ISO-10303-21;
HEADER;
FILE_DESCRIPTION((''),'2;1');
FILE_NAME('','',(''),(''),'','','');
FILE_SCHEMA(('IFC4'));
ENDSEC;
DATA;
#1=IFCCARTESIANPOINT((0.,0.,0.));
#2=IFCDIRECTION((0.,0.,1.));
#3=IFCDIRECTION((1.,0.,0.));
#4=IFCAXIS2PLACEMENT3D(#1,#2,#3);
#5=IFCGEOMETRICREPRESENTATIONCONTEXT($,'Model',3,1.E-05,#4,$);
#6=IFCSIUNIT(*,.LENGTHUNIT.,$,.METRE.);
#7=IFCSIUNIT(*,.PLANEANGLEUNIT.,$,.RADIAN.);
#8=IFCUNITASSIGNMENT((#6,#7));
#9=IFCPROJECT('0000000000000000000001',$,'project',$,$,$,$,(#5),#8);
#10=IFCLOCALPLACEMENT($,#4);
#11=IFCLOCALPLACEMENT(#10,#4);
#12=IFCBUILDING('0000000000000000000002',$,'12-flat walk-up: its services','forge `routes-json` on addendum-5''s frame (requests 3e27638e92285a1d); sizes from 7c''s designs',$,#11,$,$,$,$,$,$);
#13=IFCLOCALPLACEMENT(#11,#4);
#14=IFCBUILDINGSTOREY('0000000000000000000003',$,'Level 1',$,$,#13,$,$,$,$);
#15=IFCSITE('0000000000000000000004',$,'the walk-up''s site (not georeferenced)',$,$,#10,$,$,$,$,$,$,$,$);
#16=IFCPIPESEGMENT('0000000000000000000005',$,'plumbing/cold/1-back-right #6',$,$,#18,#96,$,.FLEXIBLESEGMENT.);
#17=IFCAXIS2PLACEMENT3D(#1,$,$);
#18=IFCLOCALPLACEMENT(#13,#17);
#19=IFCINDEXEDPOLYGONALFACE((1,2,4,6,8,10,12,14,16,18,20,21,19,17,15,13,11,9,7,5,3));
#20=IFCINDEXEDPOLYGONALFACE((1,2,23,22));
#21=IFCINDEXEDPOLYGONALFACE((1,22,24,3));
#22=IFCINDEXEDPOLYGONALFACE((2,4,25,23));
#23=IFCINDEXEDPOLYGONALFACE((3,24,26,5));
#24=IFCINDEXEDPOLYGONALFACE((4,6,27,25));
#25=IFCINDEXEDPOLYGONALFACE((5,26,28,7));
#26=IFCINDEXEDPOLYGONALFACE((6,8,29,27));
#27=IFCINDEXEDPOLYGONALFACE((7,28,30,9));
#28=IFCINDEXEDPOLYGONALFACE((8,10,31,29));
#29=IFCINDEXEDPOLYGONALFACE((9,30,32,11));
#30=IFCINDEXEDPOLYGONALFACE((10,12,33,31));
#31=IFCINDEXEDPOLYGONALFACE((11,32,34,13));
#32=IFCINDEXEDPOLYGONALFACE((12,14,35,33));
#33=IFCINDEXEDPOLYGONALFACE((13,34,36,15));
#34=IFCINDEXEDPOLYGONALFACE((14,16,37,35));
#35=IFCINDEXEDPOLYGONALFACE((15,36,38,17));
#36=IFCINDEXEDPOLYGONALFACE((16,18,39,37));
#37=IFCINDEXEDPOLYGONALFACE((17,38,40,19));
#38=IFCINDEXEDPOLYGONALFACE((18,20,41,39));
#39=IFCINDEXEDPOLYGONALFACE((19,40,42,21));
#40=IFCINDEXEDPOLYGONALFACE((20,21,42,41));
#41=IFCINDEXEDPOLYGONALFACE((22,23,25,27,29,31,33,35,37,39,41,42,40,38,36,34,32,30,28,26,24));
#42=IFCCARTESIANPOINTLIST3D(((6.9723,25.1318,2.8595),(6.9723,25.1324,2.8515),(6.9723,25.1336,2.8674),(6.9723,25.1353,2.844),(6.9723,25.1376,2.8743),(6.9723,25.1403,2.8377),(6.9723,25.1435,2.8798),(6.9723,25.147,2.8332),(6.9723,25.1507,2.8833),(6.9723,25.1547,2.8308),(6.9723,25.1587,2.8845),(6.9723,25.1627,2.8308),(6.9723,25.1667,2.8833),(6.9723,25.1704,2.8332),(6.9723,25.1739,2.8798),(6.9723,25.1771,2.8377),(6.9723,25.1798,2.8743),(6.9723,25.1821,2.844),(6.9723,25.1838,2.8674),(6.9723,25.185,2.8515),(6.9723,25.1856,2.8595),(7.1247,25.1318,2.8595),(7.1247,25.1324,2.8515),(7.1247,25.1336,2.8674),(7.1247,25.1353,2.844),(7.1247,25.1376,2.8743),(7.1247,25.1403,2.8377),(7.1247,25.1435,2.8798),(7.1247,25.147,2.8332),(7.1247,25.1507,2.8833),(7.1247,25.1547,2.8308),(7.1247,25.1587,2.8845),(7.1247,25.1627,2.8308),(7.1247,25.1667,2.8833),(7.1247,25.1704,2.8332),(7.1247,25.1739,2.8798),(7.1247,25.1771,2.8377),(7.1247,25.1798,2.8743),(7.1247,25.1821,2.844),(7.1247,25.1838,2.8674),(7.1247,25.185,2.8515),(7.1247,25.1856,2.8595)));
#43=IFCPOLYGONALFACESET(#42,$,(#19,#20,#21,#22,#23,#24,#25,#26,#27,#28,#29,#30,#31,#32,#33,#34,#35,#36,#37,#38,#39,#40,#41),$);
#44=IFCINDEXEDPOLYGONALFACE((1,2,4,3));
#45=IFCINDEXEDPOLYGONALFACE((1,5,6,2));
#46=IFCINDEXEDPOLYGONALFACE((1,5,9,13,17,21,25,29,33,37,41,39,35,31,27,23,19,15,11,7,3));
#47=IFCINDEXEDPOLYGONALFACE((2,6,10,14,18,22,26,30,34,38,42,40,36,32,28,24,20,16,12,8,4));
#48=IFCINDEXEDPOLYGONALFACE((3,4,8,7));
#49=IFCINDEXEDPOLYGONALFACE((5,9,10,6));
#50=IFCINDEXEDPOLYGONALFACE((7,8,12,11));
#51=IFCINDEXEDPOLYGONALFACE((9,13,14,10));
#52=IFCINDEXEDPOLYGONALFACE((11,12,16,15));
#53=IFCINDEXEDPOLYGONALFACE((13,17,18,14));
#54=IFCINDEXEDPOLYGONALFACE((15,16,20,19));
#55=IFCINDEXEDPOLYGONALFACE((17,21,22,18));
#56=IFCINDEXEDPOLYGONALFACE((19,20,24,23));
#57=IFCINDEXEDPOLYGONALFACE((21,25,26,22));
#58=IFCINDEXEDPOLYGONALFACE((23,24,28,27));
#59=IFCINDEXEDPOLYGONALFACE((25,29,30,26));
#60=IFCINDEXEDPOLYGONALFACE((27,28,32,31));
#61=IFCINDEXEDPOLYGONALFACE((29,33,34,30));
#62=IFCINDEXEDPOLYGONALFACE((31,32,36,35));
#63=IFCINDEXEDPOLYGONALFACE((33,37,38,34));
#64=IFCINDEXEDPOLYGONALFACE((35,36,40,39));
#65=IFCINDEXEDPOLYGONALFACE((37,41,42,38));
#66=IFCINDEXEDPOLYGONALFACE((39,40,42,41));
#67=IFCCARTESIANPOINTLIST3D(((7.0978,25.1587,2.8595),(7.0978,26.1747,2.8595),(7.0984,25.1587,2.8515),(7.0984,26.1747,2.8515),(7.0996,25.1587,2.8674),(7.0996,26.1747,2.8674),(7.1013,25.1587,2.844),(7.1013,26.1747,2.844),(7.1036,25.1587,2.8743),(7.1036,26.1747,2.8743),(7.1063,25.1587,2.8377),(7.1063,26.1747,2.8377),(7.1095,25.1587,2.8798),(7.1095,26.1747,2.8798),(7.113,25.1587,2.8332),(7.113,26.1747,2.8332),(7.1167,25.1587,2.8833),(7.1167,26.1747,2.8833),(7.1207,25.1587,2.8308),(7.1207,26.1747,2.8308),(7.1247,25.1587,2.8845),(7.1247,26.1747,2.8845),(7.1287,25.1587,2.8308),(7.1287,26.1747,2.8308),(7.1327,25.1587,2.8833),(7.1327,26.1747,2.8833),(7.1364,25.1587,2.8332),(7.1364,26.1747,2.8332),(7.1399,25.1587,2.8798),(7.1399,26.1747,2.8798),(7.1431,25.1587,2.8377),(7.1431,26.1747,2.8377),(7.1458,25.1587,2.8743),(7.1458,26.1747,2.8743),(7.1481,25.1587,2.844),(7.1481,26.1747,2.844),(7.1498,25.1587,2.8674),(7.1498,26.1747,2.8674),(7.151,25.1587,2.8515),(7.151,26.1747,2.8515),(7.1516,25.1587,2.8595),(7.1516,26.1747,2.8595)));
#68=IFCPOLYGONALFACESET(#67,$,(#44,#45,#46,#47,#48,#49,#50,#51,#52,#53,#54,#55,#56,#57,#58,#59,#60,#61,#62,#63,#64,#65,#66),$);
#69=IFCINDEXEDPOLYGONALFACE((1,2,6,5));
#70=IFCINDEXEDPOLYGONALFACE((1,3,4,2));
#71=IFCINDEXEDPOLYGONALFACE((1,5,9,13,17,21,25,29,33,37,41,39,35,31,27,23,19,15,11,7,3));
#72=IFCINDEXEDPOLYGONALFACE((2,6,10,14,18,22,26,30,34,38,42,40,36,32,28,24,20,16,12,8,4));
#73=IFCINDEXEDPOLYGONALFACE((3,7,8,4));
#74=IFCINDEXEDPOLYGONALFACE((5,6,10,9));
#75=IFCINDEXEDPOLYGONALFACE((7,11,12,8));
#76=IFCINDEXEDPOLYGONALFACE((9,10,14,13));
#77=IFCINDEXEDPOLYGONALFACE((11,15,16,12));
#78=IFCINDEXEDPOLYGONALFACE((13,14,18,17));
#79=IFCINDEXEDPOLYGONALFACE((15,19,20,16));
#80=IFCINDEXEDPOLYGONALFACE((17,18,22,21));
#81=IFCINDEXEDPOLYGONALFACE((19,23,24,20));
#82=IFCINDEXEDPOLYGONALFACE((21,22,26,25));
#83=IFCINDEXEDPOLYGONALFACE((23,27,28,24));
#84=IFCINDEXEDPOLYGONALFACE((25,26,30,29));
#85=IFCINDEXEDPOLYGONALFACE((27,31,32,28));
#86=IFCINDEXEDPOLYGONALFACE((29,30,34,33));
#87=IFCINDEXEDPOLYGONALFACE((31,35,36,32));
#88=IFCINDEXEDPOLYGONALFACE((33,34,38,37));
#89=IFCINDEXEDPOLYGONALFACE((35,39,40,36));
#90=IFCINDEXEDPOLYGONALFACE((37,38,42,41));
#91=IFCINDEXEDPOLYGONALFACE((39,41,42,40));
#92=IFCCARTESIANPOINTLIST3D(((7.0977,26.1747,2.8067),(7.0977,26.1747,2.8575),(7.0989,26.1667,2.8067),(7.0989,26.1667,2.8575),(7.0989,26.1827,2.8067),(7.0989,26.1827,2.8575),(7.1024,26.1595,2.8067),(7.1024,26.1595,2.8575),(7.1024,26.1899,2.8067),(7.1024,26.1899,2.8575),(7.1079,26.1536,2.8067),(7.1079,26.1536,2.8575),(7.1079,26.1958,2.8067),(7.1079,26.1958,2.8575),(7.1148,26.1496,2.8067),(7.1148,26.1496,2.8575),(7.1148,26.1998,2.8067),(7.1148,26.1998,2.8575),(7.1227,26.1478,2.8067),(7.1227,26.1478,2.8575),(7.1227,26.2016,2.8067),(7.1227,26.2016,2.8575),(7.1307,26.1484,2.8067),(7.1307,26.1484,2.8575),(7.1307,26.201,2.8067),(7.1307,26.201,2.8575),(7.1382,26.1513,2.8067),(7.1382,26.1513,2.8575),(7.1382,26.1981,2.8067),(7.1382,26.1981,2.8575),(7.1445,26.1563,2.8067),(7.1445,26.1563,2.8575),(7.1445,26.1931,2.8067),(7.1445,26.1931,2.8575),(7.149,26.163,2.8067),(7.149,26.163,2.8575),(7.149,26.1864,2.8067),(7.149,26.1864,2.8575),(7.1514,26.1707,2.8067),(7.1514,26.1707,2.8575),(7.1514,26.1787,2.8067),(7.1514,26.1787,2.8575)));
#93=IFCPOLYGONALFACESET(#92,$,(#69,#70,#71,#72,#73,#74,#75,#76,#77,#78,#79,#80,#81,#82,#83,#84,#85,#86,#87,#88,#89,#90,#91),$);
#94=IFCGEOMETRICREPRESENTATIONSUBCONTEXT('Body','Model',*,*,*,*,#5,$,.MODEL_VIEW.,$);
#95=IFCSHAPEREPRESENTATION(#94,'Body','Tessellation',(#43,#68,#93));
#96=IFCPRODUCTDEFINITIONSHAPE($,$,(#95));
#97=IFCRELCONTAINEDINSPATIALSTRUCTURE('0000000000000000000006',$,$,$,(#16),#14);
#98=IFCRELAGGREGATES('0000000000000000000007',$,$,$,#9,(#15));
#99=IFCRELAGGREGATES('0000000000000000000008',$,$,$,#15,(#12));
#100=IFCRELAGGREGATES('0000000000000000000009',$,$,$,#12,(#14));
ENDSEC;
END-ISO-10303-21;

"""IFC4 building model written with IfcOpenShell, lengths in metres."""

from ifc_helpers import new_model, entity, si_unit, frame, origin_with_axes, place, context, subcontext, project, spatial, element, save


model = new_model("IFC4")

# Units and contexts
model_context = context("Model", 3, precision=1e-05, world=origin_with_axes())
body_context = subcontext(model_context, "Body", "Model", "MODEL_VIEW")
ifc_project = project(units=[si_unit("LENGTHUNIT", "METRE"), si_unit("PLANEANGLEUNIT", "RADIAN")], contexts=[model_context])

# Site, building, storey
site_placement = place(None, origin_with_axes())
site = spatial("IfcSite", under=ifc_project, at=site_placement, Name="the walk-up's site (not georeferenced)")
building_placement = place(site_placement, origin_with_axes())
building = spatial("IfcBuilding", under=site, at=building_placement, Name="12-flat walk-up: its services", Description="forge `routes-json` on addendum-5's frame (requests 3e27638e92285a1d); sizes from 7c's designs")
storey_placement = place(building_placement, origin_with_axes())
storey = spatial("IfcBuildingStorey", under=building, at=storey_placement, Name="Level 1")

# Pipe segment
pipe_segment_1_placement = place(storey_placement, frame((6.9723, 25.1587, 2.8575), z_axis=(0.0, 0.0, 1.0), x_axis=(1.0, 0.0, 0.0)))
element("IfcPipeSegment", 1, at=pipe_segment_1_placement, inside=storey, Name="plumbing/cold/1-back-right #6", PredefinedType="FLEXIBLESEGMENT", context=body_context, shape_type="AdvancedSweptSolid", body=[
    entity("IfcSweptDiskSolid", entity("IfcPolyline", [entity("IfcCartesianPoint", [0.0, 0.0, 0.0]), entity("IfcCartesianPoint", [0.1524, 0.0, 0.0])]), 0.027),
    entity("IfcSweptDiskSolid", entity("IfcPolyline", [entity("IfcCartesianPoint", [0.1524, 0.0, 0.0]), entity("IfcCartesianPoint", [0.1524, 1.016, 0.0])]), 0.027),
    entity("IfcSweptDiskSolid", entity("IfcPolyline", [entity("IfcCartesianPoint", [0.1524, 1.016, 0.0]), entity("IfcCartesianPoint", [0.1524, 1.016, -0.0508])]), 0.027),
])

save(model, "model.ifc")
